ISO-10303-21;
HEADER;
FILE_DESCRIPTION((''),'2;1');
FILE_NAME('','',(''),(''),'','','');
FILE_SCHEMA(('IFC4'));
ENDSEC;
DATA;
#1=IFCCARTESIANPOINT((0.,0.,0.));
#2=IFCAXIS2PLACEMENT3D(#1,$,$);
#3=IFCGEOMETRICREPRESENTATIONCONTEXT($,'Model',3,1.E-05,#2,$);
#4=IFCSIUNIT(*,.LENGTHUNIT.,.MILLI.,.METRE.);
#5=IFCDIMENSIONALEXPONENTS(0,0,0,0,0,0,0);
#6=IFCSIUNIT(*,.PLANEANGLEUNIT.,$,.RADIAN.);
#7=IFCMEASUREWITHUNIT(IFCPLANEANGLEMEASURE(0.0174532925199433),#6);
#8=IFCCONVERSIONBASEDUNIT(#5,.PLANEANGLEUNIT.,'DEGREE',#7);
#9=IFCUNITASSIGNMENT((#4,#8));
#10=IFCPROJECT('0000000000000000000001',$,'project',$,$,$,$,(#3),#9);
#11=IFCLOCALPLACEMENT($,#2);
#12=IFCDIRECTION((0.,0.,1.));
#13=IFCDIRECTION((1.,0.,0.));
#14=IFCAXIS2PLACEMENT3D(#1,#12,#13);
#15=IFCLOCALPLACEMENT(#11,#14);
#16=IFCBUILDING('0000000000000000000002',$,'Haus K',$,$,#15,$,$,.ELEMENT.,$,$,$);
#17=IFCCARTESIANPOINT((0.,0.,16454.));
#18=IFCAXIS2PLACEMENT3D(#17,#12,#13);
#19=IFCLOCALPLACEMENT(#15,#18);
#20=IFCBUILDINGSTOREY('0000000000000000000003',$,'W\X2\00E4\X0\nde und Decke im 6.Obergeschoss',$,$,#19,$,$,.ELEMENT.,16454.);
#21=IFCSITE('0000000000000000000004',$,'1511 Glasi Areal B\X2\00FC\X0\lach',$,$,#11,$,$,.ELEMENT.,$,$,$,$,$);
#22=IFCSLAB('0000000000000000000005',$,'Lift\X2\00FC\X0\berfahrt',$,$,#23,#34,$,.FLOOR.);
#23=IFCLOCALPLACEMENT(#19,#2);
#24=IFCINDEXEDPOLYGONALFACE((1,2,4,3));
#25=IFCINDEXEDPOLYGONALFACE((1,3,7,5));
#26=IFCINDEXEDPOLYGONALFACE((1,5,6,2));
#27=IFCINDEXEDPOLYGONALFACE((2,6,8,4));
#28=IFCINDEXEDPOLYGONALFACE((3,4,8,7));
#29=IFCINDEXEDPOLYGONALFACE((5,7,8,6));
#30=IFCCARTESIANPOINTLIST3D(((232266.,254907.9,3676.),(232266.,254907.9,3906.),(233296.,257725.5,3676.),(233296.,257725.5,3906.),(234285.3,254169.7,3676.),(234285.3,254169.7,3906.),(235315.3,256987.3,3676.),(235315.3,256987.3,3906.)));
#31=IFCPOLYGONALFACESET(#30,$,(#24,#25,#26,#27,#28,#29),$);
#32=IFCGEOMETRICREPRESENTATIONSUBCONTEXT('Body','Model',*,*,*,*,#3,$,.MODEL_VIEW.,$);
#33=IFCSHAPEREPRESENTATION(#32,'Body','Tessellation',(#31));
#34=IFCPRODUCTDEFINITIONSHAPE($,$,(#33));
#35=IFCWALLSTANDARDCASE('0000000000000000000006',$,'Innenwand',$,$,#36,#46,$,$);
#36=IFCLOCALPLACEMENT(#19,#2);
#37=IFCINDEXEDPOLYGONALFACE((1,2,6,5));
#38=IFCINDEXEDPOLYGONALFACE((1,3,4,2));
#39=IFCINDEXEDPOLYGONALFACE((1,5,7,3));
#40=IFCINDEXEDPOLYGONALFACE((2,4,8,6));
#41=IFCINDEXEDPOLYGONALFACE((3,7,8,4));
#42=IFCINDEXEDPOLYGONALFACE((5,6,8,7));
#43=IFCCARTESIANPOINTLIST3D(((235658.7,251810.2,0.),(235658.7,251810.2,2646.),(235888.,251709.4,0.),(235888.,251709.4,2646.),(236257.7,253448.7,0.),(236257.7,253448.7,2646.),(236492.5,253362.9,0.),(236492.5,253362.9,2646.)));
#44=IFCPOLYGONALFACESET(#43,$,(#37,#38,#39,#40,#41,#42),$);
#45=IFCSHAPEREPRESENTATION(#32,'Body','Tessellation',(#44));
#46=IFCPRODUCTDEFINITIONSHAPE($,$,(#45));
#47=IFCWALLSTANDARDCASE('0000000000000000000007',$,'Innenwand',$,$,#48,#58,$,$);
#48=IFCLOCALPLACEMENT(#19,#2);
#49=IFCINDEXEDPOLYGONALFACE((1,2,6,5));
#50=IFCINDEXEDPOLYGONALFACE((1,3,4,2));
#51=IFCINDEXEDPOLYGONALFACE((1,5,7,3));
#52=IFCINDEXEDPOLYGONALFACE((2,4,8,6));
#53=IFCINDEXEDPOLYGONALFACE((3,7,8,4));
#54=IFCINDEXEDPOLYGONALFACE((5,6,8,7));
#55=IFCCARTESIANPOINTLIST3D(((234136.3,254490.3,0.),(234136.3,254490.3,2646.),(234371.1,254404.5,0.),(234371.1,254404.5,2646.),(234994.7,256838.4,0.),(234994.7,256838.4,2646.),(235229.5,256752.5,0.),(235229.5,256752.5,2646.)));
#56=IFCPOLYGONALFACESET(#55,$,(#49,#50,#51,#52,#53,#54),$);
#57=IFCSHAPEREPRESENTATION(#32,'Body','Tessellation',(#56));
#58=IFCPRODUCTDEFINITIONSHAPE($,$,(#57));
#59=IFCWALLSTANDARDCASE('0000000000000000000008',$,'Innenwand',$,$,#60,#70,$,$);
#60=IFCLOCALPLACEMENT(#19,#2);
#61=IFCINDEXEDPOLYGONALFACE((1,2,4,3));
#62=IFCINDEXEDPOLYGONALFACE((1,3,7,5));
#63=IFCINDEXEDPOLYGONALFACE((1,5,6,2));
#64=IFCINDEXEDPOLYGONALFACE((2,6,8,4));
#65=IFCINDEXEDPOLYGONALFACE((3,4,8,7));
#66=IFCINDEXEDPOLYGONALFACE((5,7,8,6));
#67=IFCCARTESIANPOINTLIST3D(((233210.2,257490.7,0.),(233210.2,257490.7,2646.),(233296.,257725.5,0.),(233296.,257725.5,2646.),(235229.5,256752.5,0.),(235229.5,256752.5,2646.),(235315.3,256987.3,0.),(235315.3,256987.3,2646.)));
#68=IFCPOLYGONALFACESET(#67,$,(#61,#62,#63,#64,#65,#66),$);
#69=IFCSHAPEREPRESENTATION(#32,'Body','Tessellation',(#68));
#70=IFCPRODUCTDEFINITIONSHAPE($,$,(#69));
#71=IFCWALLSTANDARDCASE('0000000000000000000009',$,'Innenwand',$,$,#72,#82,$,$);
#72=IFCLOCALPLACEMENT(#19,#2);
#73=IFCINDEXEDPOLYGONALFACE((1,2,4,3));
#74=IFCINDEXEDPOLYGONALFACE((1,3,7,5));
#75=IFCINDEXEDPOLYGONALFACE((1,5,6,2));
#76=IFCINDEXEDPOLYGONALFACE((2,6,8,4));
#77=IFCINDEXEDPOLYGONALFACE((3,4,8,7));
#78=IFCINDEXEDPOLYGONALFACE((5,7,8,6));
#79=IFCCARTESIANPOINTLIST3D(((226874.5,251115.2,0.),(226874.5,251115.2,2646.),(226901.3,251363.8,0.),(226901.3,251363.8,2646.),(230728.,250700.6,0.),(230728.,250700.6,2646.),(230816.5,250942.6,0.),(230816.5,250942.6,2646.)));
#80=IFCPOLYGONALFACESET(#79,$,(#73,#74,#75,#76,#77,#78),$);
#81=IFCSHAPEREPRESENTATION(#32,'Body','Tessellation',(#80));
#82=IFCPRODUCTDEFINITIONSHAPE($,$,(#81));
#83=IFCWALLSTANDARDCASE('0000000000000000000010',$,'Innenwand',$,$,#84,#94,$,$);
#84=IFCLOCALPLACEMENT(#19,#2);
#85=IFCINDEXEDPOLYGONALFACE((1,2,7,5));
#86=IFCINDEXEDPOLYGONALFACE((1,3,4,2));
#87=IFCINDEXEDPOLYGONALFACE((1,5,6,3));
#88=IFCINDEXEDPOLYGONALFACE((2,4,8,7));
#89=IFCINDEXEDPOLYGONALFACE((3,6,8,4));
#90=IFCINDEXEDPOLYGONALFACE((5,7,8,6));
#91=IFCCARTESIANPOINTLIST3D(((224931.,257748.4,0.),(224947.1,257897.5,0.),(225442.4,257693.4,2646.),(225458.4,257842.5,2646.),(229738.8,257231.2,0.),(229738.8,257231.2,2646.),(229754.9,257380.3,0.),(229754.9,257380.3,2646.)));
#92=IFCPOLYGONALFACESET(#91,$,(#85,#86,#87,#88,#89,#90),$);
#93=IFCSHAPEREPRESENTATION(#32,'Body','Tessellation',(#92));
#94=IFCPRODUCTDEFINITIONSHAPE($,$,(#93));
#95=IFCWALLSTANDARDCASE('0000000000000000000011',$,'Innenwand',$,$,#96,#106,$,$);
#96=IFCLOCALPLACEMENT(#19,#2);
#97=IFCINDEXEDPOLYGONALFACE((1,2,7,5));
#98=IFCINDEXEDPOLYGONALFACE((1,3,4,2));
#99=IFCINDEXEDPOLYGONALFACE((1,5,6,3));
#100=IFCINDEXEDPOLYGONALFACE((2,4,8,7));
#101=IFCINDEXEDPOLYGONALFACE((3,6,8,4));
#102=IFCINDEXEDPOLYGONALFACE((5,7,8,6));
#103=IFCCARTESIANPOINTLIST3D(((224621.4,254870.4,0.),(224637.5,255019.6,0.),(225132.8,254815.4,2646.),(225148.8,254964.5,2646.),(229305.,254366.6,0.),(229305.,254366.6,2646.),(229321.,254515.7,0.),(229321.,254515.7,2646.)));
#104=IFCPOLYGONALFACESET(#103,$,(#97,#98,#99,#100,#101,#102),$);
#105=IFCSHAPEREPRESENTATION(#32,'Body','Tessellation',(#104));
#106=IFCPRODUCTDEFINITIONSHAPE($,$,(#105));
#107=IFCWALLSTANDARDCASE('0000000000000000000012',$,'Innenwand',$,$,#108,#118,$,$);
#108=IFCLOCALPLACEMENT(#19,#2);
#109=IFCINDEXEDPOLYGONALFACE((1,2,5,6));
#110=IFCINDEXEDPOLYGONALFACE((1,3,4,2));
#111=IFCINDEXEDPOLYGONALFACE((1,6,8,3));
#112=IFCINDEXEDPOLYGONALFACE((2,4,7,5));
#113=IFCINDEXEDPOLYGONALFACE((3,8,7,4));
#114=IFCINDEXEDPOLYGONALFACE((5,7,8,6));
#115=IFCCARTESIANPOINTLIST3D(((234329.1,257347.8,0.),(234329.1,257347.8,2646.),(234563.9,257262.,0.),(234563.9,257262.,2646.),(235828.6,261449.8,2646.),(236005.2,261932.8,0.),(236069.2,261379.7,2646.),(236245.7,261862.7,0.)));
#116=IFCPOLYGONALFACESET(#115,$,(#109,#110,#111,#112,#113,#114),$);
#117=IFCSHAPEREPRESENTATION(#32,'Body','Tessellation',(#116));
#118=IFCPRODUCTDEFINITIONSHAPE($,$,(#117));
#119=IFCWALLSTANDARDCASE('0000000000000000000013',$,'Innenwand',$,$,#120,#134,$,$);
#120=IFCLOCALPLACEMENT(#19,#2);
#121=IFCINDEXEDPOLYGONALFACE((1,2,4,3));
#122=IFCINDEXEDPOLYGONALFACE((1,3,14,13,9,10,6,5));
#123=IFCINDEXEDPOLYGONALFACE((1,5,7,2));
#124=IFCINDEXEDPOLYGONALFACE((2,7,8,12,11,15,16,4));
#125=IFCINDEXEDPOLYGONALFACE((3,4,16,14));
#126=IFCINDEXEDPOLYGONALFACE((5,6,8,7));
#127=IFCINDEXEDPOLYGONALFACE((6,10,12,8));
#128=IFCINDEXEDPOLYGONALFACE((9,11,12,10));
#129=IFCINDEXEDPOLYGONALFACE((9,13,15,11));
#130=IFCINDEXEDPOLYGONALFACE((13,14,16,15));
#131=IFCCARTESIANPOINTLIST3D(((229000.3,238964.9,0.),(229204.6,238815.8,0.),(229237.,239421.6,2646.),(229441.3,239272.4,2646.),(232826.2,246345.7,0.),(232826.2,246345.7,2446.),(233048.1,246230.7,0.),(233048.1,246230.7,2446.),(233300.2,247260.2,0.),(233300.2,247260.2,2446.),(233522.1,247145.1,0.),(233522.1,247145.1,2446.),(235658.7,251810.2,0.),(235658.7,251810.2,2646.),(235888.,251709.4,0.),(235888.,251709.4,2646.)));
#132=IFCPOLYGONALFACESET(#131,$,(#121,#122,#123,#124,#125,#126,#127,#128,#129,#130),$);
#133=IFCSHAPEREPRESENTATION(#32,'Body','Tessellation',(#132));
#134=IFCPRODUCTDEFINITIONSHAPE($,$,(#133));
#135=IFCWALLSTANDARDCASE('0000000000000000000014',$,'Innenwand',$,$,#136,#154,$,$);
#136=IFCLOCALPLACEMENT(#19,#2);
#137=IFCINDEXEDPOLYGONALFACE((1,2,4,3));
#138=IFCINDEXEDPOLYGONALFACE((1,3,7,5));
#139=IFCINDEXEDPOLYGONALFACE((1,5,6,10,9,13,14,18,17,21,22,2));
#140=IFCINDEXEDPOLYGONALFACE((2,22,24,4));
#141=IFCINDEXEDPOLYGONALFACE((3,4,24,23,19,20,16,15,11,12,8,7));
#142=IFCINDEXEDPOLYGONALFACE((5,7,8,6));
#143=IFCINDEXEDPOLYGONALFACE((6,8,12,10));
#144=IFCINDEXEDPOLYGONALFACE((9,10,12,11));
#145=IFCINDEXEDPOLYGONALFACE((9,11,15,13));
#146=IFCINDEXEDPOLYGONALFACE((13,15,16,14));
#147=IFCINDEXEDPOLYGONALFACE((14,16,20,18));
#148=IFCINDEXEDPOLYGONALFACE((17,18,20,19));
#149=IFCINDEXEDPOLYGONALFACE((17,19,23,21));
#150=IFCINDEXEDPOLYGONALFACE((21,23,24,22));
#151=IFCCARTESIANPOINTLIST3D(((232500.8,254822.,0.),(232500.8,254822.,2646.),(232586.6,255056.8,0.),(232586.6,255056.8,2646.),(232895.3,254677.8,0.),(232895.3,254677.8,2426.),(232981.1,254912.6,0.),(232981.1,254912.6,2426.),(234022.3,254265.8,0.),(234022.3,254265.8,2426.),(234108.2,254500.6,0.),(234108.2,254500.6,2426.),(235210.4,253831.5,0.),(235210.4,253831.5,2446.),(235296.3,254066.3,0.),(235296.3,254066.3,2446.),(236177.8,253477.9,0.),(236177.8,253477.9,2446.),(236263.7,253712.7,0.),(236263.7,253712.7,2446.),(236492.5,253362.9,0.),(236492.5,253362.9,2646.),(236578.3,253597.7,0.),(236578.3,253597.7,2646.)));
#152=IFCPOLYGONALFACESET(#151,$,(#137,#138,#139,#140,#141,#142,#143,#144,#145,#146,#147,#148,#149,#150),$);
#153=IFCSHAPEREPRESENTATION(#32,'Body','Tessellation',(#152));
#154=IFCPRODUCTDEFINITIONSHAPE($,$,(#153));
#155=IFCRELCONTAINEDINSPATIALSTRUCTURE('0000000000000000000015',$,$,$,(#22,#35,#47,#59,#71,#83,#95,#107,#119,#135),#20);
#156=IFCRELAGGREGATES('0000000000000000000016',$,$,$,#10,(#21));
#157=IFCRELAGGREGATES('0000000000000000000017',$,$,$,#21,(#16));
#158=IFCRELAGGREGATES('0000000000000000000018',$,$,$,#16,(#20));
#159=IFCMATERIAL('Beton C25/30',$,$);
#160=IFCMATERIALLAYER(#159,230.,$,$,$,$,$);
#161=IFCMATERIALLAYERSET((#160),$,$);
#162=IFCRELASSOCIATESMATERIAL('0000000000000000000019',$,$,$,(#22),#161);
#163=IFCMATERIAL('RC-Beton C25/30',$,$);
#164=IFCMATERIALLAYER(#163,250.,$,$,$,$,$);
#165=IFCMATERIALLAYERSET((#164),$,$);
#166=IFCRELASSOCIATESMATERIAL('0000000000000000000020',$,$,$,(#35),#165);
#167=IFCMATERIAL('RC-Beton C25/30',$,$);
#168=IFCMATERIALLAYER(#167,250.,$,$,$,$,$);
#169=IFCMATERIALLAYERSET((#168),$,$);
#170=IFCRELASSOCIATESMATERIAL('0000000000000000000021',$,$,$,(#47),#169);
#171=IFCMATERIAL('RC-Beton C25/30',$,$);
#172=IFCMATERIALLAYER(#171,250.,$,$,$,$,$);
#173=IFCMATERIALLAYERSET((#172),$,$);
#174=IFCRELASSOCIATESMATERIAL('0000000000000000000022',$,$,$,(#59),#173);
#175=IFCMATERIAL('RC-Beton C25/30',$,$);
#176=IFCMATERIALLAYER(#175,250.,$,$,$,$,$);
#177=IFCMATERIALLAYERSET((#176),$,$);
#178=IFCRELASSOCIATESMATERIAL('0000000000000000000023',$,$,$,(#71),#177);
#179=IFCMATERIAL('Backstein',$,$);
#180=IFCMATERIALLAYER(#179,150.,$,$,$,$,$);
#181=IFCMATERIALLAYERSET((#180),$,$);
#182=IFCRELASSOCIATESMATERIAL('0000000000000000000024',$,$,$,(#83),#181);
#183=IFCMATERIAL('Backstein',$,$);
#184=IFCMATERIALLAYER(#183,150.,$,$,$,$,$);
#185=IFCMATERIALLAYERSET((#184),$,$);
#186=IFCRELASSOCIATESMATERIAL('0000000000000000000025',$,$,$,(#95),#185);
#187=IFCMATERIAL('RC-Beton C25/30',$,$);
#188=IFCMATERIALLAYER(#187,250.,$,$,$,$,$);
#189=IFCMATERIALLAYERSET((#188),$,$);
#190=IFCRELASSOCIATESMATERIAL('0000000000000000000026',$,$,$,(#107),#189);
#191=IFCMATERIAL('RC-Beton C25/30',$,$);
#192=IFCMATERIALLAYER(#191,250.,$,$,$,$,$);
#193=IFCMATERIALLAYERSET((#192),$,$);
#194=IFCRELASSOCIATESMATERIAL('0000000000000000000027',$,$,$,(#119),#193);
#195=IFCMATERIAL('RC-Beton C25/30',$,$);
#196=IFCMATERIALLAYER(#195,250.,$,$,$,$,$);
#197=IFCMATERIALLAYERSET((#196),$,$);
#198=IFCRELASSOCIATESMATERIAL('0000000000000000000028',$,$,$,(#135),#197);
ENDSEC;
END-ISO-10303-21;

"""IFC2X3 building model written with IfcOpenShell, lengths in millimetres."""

from ifc_helpers import new_model, entity, si_unit, converted_unit, frame, frame_2d, origin, origin_with_axes, place, context, subcontext, project, spatial, polyline, rectangle, outline, extrude, clip, bounded_halfspace, material, layer, layer_set, layer_usage, element, save


model = new_model("IFC2X3")

# Units and contexts
model_context = context("Model", 3, precision=1e-05, world=origin())
body_context = subcontext(model_context, "Body", "Model", "MODEL_VIEW")
ifc_project = project(units=[si_unit("LENGTHUNIT", "METRE", prefix="MILLI"), converted_unit("PLANEANGLEUNIT", "DEGREE", entity("IfcPlaneAngleMeasure", 0.0174532925199433), si_unit("PLANEANGLEUNIT", "RADIAN"), dimensions=[0, 0, 0, 0, 0, 0, 0])], contexts=[model_context])

# Site, building, storey
site_placement = place(None, origin())
site = spatial("IfcSite", under=ifc_project, at=site_placement, Name="1511 Glasi Areal Bülach", CompositionType="ELEMENT")
building_placement = place(site_placement, origin_with_axes())
building = spatial("IfcBuilding", under=site, at=building_placement, Name="Haus K", CompositionType="ELEMENT")
storey_placement = place(building_placement, frame((0.0, 0.0, 16454.0), z_axis=(0.0, 0.0, 1.0), x_axis=(1.0, 0.0, 0.0)))
storey = spatial("IfcBuildingStorey", under=building, at=storey_placement, Name="Wände und Decke im 6.Obergeschoss", CompositionType="ELEMENT", Elevation=16454.0)

# Slab
ifc_material_1 = material(Name="Beton C25/30")
ifc_layer_1 = layer(ifc_material_1, 230.0)
ifc_layer_set_1 = layer_set([ifc_layer_1])
ifc_layer_usage_1 = layer_usage(ifc_layer_set_1, "AXIS3", "POSITIVE", 0.0)
slab_placement = place(storey_placement, frame((233296.0, 257725.5, 3676.0), z_axis=(0.0, 0.0, 1.0), x_axis=(1.0, 0.0, 0.0)))
element("IfcSlab", 1, at=slab_placement, inside=storey, material=ifc_layer_usage_1, Name="Liftüberfahrt", PredefinedType="FLOOR", context=body_context, shape_type="SweptSolid", body=[
    extrude(rectangle(XDim=3000.0, YDim=2150.0, at=frame_2d((494.7, -1777.9), x_axis=(-0.343332, -0.939214))), origin_with_axes(), (0.0, 0.0, 1.0), 230.0),
])

# Walls
ifc_material_2 = material(Name="RC-Beton C25/30")
ifc_layer_2 = layer(ifc_material_2, 250.0)
ifc_layer_set_2 = layer_set([ifc_layer_2])
ifc_layer_usage_2 = layer_usage(ifc_layer_set_2, "AXIS2", "POSITIVE", 0.0)
wall_1_placement = place(storey_placement, frame((236257.7, 253448.7, 0.0), z_axis=(0.0, 0.0, 1.0), x_axis=(-0.343332, -0.939214, 0.0)))
element("IfcWallStandardCase", 2, at=wall_1_placement, inside=storey, material=ifc_layer_usage_2, Name="Innenwand", context=body_context, shape_type="SweptSolid", body=[
    extrude(outline(polyline([(0.0, 0.0), (1744.5, 0.0), (1760.5, 250.0), (0.0, 250.0), (0.0, 0.0)])), origin_with_axes(), (0.0, 0.0, 1.0), 2646.0),
])
ifc_material_3 = material(Name="RC-Beton C25/30")
ifc_layer_3 = layer(ifc_material_3, 250.0)
ifc_layer_set_3 = layer_set([ifc_layer_3])
ifc_layer_usage_3 = layer_usage(ifc_layer_set_3, "AXIS2", "POSITIVE", 0.0)
wall_2_placement = place(storey_placement, frame((234371.1, 254404.5, 0.0), z_axis=(0.0, 0.0, 1.0), x_axis=(0.343332, 0.939214, 0.0)))
element("IfcWallStandardCase", 3, at=wall_2_placement, inside=storey, material=ifc_layer_usage_3, Name="Innenwand", context=body_context, shape_type="SweptSolid", body=[
    extrude(rectangle(XDim=2500.0, YDim=250.0, at=frame_2d((1250.0, 125.0), x_axis=(1.0, 0.0))), origin_with_axes(), (0.0, 0.0, 1.0), 2646.0),
])
ifc_material_4 = material(Name="RC-Beton C25/30")
ifc_layer_4 = layer(ifc_material_4, 250.0)
ifc_layer_set_4 = layer_set([ifc_layer_4])
ifc_layer_usage_4 = layer_usage(ifc_layer_set_4, "AXIS2", "POSITIVE", 0.0)
wall_3_placement = place(storey_placement, frame((235315.3, 256987.3, 0.0), z_axis=(0.0, 0.0, 1.0), x_axis=(-0.939214, 0.343332, 0.0)))
element("IfcWallStandardCase", 4, at=wall_3_placement, inside=storey, material=ifc_layer_usage_4, Name="Innenwand", context=body_context, shape_type="SweptSolid", body=[
    extrude(rectangle(XDim=2150.0, YDim=250.0, at=frame_2d((1075.0, 125.0), x_axis=(1.0, 0.0))), origin_with_axes(), (0.0, 0.0, 1.0), 2646.0),
])
ifc_material_5 = material(Name="RC-Beton C25/30")
ifc_layer_5 = layer(ifc_material_5, 250.0)
ifc_layer_set_5 = layer_set([ifc_layer_5])
ifc_layer_usage_5 = layer_usage(ifc_layer_set_5, "AXIS2", "POSITIVE", 0.0)
wall_4_placement = place(storey_placement, frame((230816.5, 250942.6, 0.0), z_axis=(0.0, 0.0, 1.0), x_axis=(-0.994264, 0.106958, 0.0)))
element("IfcWallStandardCase", 5, at=wall_4_placement, inside=storey, material=ifc_layer_usage_5, Name="Innenwand", context=body_context, shape_type="SweptSolid", body=[
    extrude(outline(polyline([(0.0, 0.0), (3937.8, 0.0), (3937.8, 250.0), (62.1, 250.0), (0.0, 0.0)])), origin_with_axes(), (0.0, 0.0, 1.0), 2646.0),
])
ifc_material_6 = material(Name="Backstein")
ifc_layer_6 = layer(ifc_material_6, 150.0)
ifc_layer_set_6 = layer_set([ifc_layer_6])
ifc_layer_usage_6 = layer_usage(ifc_layer_set_6, "AXIS2", "POSITIVE", 0.0)
wall_5_placement = place(storey_placement, frame((224931.0, 257748.4, 0.0), z_axis=(0.0, 0.0, 1.0), x_axis=(0.994264, -0.106958, 0.0)))
element("IfcWallStandardCase", 6, at=wall_5_placement, inside=storey, material=ifc_layer_usage_6, Name="Innenwand", context=body_context, shape_type="Clipping", body=[
    clip(clip(extrude(rectangle(XDim=4835.6, YDim=150.0, at=frame_2d((2417.8, 75.0), x_axis=(1.0, 0.0))), origin_with_axes(), (0.0, 0.0, 1.0), 2646.0), bounded_halfspace(frame((514.3, 150.0, 2646.0), z_axis=(0.981627, 0.0, -0.190809), x_axis=(-0.190809, 0.0, -0.981627)), True, origin(), polyline([(514.3, 150.0), (0.0, 150.0), (0.0, 0.0), (514.3, 0.0), (514.3, 150.0)]))), bounded_halfspace(frame((514.3, 150.0, 2646.0), z_axis=(0.0, 0.0, -1.0), x_axis=(0.0, -1.0, 0.0)), True, origin(), polyline([(514.3, 150.0), (514.3, 0.0), (4835.6, 0.0), (4835.6, 150.0), (514.3, 150.0)]))),
])
ifc_material_7 = material(Name="Backstein")
ifc_layer_7 = layer(ifc_material_7, 150.0)
ifc_layer_set_7 = layer_set([ifc_layer_7])
ifc_layer_usage_7 = layer_usage(ifc_layer_set_7, "AXIS2", "POSITIVE", 0.0)
wall_6_placement = place(storey_placement, frame((229321.0, 254515.7, 0.0), z_axis=(0.0, 0.0, 1.0), x_axis=(-0.994264, 0.106958, 0.0)))
element("IfcWallStandardCase", 7, at=wall_6_placement, inside=storey, material=ifc_layer_usage_7, Name="Innenwand", context=body_context, shape_type="Clipping", body=[
    clip(clip(extrude(rectangle(XDim=4710.6, YDim=150.0, at=frame_2d((2355.3, 75.0), x_axis=(1.0, 0.0))), origin_with_axes(), (0.0, 0.0, 1.0), 2646.0), bounded_halfspace(frame((4196.2, 0.0, 2646.0), z_axis=(-0.981627, 0.0, -0.190809), x_axis=(0.190809, 0.0, -0.981627)), True, origin(), polyline([(4196.2, 0.0), (4710.6, 0.0), (4710.6, 150.0), (4196.2, 150.0), (4196.2, 0.0)]))), bounded_halfspace(frame((4196.2, 0.0, 2646.0), z_axis=(0.0, 0.0, -1.0), x_axis=(0.0, 1.0, 0.0)), True, origin(), polyline([(4196.2, 0.0), (4196.2, 150.0), (0.0, 150.0), (0.0, 0.0), (4196.2, 0.0)]))),
])
ifc_material_8 = material(Name="RC-Beton C25/30")
ifc_layer_8 = layer(ifc_material_8, 250.0)
ifc_layer_set_8 = layer_set([ifc_layer_8])
ifc_layer_usage_8 = layer_usage(ifc_layer_set_8, "AXIS2", "POSITIVE", 0.0)
wall_7_placement = place(storey_placement, frame((234563.9, 257262.0, 0.0), z_axis=(0.0, 0.0, 1.0), x_axis=(0.343332, 0.939214, 0.0)))
element("IfcWallStandardCase", 8, at=wall_7_placement, inside=storey, material=ifc_layer_usage_8, Name="Innenwand", context=body_context, shape_type="Clipping", body=[
    clip(clip(extrude(outline(polyline([(0.0, 0.0), (4898.5, 0.0), (4881.7, 250.0), (0.0, 250.0), (0.0, 0.0)])), origin_with_axes(), (0.0, 0.0, 1.0), 2646.0), bounded_halfspace(frame((4384.2, 0.0, 2646.0), z_axis=(-0.979503, -0.065745, -0.190396), x_axis=(0.190809, 0.0, -0.981627)), True, origin(), polyline([(4384.2, 0.0), (4898.5, 0.0), (4881.7, 250.0), (4367.4, 250.0), (4384.2, 0.0)]))), bounded_halfspace(frame((4384.2, 0.0, 2646.0), z_axis=(0.0, 0.0, -1.0), x_axis=(-0.06697, 0.997755, 0.0)), True, origin(), polyline([(4384.2, 0.0), (4367.4, 250.0), (0.0, 250.0), (0.0, 0.0), (4384.2, 0.0)]))),
])

# Wall, opening
ifc_material_9 = material(Name="RC-Beton C25/30")
ifc_layer_9 = layer(ifc_material_9, 250.0)
ifc_layer_set_9 = layer_set([ifc_layer_9])
ifc_layer_usage_9 = layer_usage(ifc_layer_set_9, "AXIS2", "POSITIVE", 0.0)
wall_8_placement = place(storey_placement, frame((235658.7, 251810.2, 0.0), z_axis=(0.0, 0.0, 1.0), x_axis=(-0.4602, -0.887815, 0.0)))
wall_8 = element("IfcWallStandardCase", 9, at=wall_8_placement, inside=storey, material=ifc_layer_usage_9, Name="Innenwand", context=body_context, shape_type="Clipping", body=[
    clip(clip(extrude(outline(polyline([(0.0, 0.0), (14468.4, 0.0), (14506.8, 250.0), (-16.0, 250.0), (0.0, 0.0)])), origin_with_axes(), (0.0, 0.0, 1.0), 2646.0), bounded_halfspace(frame((13954.1, 0.0, 2646.0), z_axis=(-0.970662, 0.149052, -0.188678), x_axis=(0.190809, 0.0, -0.981627)), True, origin(), polyline([(13954.1, 0.0), (14468.4, 0.0), (14506.8, 250.0), (13992.5, 250.0), (13954.1, 0.0)]))), bounded_halfspace(frame((13954.1, 0.0, 2646.0), z_axis=(0.0, 0.0, -1.0), x_axis=(0.151778, 0.988415, 0.0)), True, origin(), polyline([(13954.1, 0.0), (13992.5, 250.0), (-16.0, 250.0), (0.0, 0.0), (13954.1, 0.0)]))),
])
opening_1_placement = place(wall_8_placement, frame((5125.0, 0.0, 0.0), z_axis=(0.0, 1.0, 0.0), x_axis=(0.0, 0.0, 1.0)))
element("IfcOpeningElement", 10, at=opening_1_placement, cuts=wall_8, ObjectType="Opening", context=body_context, shape_type="SweptSolid", body=[
    extrude(rectangle(XDim=2446.0, YDim=1030.0, at=frame_2d((1223.0, 515.0), x_axis=(1.0, 0.0))), origin_with_axes(), (0.0, 0.0, 1.0), 250.0),
])

# Wall, openings
ifc_material_10 = material(Name="RC-Beton C25/30")
ifc_layer_10 = layer(ifc_material_10, 250.0)
ifc_layer_set_10 = layer_set([ifc_layer_10])
ifc_layer_usage_10 = layer_usage(ifc_layer_set_10, "AXIS2", "POSITIVE", 0.0)
wall_9_placement = place(storey_placement, frame((232500.8, 254822.0, 0.0), z_axis=(0.0, 0.0, 1.0), x_axis=(0.939214, -0.343332, 0.0)))
wall_9 = element("IfcWallStandardCase", 11, at=wall_9_placement, inside=storey, material=ifc_layer_usage_10, Name="Innenwand", context=body_context, shape_type="SweptSolid", body=[
    extrude(rectangle(XDim=4250.0, YDim=250.0, at=frame_2d((2125.0, 125.0), x_axis=(1.0, 0.0))), origin_with_axes(), (0.0, 0.0, 1.0), 2646.0),
])
opening_2_placement = place(wall_9_placement, frame((2885.0, 0.0, 0.0), z_axis=(0.0, 1.0, 0.0), x_axis=(0.0, 0.0, 1.0)))
element("IfcOpeningElement", 12, at=opening_2_placement, cuts=wall_9, ObjectType="Opening", context=body_context, shape_type="SweptSolid", body=[
    extrude(rectangle(XDim=2446.0, YDim=1030.0, at=frame_2d((1223.0, 515.0), x_axis=(1.0, 0.0))), origin_with_axes(), (0.0, 0.0, 1.0), 250.0),
])
opening_3_placement = place(wall_9_placement, frame((420.0, 0.0, 0.0), z_axis=(0.0, 1.0, 0.0), x_axis=(0.0, 0.0, 1.0)))
element("IfcOpeningElement", 13, at=opening_3_placement, cuts=wall_9, ObjectType="Opening", context=body_context, shape_type="SweptSolid", body=[
    extrude(rectangle(XDim=2426.0, YDim=1200.0, at=frame_2d((1213.0, 600.0), x_axis=(1.0, 0.0))), origin_with_axes(), (0.0, 0.0, 1.0), 250.0),
])

save(model, "model.ifc")
